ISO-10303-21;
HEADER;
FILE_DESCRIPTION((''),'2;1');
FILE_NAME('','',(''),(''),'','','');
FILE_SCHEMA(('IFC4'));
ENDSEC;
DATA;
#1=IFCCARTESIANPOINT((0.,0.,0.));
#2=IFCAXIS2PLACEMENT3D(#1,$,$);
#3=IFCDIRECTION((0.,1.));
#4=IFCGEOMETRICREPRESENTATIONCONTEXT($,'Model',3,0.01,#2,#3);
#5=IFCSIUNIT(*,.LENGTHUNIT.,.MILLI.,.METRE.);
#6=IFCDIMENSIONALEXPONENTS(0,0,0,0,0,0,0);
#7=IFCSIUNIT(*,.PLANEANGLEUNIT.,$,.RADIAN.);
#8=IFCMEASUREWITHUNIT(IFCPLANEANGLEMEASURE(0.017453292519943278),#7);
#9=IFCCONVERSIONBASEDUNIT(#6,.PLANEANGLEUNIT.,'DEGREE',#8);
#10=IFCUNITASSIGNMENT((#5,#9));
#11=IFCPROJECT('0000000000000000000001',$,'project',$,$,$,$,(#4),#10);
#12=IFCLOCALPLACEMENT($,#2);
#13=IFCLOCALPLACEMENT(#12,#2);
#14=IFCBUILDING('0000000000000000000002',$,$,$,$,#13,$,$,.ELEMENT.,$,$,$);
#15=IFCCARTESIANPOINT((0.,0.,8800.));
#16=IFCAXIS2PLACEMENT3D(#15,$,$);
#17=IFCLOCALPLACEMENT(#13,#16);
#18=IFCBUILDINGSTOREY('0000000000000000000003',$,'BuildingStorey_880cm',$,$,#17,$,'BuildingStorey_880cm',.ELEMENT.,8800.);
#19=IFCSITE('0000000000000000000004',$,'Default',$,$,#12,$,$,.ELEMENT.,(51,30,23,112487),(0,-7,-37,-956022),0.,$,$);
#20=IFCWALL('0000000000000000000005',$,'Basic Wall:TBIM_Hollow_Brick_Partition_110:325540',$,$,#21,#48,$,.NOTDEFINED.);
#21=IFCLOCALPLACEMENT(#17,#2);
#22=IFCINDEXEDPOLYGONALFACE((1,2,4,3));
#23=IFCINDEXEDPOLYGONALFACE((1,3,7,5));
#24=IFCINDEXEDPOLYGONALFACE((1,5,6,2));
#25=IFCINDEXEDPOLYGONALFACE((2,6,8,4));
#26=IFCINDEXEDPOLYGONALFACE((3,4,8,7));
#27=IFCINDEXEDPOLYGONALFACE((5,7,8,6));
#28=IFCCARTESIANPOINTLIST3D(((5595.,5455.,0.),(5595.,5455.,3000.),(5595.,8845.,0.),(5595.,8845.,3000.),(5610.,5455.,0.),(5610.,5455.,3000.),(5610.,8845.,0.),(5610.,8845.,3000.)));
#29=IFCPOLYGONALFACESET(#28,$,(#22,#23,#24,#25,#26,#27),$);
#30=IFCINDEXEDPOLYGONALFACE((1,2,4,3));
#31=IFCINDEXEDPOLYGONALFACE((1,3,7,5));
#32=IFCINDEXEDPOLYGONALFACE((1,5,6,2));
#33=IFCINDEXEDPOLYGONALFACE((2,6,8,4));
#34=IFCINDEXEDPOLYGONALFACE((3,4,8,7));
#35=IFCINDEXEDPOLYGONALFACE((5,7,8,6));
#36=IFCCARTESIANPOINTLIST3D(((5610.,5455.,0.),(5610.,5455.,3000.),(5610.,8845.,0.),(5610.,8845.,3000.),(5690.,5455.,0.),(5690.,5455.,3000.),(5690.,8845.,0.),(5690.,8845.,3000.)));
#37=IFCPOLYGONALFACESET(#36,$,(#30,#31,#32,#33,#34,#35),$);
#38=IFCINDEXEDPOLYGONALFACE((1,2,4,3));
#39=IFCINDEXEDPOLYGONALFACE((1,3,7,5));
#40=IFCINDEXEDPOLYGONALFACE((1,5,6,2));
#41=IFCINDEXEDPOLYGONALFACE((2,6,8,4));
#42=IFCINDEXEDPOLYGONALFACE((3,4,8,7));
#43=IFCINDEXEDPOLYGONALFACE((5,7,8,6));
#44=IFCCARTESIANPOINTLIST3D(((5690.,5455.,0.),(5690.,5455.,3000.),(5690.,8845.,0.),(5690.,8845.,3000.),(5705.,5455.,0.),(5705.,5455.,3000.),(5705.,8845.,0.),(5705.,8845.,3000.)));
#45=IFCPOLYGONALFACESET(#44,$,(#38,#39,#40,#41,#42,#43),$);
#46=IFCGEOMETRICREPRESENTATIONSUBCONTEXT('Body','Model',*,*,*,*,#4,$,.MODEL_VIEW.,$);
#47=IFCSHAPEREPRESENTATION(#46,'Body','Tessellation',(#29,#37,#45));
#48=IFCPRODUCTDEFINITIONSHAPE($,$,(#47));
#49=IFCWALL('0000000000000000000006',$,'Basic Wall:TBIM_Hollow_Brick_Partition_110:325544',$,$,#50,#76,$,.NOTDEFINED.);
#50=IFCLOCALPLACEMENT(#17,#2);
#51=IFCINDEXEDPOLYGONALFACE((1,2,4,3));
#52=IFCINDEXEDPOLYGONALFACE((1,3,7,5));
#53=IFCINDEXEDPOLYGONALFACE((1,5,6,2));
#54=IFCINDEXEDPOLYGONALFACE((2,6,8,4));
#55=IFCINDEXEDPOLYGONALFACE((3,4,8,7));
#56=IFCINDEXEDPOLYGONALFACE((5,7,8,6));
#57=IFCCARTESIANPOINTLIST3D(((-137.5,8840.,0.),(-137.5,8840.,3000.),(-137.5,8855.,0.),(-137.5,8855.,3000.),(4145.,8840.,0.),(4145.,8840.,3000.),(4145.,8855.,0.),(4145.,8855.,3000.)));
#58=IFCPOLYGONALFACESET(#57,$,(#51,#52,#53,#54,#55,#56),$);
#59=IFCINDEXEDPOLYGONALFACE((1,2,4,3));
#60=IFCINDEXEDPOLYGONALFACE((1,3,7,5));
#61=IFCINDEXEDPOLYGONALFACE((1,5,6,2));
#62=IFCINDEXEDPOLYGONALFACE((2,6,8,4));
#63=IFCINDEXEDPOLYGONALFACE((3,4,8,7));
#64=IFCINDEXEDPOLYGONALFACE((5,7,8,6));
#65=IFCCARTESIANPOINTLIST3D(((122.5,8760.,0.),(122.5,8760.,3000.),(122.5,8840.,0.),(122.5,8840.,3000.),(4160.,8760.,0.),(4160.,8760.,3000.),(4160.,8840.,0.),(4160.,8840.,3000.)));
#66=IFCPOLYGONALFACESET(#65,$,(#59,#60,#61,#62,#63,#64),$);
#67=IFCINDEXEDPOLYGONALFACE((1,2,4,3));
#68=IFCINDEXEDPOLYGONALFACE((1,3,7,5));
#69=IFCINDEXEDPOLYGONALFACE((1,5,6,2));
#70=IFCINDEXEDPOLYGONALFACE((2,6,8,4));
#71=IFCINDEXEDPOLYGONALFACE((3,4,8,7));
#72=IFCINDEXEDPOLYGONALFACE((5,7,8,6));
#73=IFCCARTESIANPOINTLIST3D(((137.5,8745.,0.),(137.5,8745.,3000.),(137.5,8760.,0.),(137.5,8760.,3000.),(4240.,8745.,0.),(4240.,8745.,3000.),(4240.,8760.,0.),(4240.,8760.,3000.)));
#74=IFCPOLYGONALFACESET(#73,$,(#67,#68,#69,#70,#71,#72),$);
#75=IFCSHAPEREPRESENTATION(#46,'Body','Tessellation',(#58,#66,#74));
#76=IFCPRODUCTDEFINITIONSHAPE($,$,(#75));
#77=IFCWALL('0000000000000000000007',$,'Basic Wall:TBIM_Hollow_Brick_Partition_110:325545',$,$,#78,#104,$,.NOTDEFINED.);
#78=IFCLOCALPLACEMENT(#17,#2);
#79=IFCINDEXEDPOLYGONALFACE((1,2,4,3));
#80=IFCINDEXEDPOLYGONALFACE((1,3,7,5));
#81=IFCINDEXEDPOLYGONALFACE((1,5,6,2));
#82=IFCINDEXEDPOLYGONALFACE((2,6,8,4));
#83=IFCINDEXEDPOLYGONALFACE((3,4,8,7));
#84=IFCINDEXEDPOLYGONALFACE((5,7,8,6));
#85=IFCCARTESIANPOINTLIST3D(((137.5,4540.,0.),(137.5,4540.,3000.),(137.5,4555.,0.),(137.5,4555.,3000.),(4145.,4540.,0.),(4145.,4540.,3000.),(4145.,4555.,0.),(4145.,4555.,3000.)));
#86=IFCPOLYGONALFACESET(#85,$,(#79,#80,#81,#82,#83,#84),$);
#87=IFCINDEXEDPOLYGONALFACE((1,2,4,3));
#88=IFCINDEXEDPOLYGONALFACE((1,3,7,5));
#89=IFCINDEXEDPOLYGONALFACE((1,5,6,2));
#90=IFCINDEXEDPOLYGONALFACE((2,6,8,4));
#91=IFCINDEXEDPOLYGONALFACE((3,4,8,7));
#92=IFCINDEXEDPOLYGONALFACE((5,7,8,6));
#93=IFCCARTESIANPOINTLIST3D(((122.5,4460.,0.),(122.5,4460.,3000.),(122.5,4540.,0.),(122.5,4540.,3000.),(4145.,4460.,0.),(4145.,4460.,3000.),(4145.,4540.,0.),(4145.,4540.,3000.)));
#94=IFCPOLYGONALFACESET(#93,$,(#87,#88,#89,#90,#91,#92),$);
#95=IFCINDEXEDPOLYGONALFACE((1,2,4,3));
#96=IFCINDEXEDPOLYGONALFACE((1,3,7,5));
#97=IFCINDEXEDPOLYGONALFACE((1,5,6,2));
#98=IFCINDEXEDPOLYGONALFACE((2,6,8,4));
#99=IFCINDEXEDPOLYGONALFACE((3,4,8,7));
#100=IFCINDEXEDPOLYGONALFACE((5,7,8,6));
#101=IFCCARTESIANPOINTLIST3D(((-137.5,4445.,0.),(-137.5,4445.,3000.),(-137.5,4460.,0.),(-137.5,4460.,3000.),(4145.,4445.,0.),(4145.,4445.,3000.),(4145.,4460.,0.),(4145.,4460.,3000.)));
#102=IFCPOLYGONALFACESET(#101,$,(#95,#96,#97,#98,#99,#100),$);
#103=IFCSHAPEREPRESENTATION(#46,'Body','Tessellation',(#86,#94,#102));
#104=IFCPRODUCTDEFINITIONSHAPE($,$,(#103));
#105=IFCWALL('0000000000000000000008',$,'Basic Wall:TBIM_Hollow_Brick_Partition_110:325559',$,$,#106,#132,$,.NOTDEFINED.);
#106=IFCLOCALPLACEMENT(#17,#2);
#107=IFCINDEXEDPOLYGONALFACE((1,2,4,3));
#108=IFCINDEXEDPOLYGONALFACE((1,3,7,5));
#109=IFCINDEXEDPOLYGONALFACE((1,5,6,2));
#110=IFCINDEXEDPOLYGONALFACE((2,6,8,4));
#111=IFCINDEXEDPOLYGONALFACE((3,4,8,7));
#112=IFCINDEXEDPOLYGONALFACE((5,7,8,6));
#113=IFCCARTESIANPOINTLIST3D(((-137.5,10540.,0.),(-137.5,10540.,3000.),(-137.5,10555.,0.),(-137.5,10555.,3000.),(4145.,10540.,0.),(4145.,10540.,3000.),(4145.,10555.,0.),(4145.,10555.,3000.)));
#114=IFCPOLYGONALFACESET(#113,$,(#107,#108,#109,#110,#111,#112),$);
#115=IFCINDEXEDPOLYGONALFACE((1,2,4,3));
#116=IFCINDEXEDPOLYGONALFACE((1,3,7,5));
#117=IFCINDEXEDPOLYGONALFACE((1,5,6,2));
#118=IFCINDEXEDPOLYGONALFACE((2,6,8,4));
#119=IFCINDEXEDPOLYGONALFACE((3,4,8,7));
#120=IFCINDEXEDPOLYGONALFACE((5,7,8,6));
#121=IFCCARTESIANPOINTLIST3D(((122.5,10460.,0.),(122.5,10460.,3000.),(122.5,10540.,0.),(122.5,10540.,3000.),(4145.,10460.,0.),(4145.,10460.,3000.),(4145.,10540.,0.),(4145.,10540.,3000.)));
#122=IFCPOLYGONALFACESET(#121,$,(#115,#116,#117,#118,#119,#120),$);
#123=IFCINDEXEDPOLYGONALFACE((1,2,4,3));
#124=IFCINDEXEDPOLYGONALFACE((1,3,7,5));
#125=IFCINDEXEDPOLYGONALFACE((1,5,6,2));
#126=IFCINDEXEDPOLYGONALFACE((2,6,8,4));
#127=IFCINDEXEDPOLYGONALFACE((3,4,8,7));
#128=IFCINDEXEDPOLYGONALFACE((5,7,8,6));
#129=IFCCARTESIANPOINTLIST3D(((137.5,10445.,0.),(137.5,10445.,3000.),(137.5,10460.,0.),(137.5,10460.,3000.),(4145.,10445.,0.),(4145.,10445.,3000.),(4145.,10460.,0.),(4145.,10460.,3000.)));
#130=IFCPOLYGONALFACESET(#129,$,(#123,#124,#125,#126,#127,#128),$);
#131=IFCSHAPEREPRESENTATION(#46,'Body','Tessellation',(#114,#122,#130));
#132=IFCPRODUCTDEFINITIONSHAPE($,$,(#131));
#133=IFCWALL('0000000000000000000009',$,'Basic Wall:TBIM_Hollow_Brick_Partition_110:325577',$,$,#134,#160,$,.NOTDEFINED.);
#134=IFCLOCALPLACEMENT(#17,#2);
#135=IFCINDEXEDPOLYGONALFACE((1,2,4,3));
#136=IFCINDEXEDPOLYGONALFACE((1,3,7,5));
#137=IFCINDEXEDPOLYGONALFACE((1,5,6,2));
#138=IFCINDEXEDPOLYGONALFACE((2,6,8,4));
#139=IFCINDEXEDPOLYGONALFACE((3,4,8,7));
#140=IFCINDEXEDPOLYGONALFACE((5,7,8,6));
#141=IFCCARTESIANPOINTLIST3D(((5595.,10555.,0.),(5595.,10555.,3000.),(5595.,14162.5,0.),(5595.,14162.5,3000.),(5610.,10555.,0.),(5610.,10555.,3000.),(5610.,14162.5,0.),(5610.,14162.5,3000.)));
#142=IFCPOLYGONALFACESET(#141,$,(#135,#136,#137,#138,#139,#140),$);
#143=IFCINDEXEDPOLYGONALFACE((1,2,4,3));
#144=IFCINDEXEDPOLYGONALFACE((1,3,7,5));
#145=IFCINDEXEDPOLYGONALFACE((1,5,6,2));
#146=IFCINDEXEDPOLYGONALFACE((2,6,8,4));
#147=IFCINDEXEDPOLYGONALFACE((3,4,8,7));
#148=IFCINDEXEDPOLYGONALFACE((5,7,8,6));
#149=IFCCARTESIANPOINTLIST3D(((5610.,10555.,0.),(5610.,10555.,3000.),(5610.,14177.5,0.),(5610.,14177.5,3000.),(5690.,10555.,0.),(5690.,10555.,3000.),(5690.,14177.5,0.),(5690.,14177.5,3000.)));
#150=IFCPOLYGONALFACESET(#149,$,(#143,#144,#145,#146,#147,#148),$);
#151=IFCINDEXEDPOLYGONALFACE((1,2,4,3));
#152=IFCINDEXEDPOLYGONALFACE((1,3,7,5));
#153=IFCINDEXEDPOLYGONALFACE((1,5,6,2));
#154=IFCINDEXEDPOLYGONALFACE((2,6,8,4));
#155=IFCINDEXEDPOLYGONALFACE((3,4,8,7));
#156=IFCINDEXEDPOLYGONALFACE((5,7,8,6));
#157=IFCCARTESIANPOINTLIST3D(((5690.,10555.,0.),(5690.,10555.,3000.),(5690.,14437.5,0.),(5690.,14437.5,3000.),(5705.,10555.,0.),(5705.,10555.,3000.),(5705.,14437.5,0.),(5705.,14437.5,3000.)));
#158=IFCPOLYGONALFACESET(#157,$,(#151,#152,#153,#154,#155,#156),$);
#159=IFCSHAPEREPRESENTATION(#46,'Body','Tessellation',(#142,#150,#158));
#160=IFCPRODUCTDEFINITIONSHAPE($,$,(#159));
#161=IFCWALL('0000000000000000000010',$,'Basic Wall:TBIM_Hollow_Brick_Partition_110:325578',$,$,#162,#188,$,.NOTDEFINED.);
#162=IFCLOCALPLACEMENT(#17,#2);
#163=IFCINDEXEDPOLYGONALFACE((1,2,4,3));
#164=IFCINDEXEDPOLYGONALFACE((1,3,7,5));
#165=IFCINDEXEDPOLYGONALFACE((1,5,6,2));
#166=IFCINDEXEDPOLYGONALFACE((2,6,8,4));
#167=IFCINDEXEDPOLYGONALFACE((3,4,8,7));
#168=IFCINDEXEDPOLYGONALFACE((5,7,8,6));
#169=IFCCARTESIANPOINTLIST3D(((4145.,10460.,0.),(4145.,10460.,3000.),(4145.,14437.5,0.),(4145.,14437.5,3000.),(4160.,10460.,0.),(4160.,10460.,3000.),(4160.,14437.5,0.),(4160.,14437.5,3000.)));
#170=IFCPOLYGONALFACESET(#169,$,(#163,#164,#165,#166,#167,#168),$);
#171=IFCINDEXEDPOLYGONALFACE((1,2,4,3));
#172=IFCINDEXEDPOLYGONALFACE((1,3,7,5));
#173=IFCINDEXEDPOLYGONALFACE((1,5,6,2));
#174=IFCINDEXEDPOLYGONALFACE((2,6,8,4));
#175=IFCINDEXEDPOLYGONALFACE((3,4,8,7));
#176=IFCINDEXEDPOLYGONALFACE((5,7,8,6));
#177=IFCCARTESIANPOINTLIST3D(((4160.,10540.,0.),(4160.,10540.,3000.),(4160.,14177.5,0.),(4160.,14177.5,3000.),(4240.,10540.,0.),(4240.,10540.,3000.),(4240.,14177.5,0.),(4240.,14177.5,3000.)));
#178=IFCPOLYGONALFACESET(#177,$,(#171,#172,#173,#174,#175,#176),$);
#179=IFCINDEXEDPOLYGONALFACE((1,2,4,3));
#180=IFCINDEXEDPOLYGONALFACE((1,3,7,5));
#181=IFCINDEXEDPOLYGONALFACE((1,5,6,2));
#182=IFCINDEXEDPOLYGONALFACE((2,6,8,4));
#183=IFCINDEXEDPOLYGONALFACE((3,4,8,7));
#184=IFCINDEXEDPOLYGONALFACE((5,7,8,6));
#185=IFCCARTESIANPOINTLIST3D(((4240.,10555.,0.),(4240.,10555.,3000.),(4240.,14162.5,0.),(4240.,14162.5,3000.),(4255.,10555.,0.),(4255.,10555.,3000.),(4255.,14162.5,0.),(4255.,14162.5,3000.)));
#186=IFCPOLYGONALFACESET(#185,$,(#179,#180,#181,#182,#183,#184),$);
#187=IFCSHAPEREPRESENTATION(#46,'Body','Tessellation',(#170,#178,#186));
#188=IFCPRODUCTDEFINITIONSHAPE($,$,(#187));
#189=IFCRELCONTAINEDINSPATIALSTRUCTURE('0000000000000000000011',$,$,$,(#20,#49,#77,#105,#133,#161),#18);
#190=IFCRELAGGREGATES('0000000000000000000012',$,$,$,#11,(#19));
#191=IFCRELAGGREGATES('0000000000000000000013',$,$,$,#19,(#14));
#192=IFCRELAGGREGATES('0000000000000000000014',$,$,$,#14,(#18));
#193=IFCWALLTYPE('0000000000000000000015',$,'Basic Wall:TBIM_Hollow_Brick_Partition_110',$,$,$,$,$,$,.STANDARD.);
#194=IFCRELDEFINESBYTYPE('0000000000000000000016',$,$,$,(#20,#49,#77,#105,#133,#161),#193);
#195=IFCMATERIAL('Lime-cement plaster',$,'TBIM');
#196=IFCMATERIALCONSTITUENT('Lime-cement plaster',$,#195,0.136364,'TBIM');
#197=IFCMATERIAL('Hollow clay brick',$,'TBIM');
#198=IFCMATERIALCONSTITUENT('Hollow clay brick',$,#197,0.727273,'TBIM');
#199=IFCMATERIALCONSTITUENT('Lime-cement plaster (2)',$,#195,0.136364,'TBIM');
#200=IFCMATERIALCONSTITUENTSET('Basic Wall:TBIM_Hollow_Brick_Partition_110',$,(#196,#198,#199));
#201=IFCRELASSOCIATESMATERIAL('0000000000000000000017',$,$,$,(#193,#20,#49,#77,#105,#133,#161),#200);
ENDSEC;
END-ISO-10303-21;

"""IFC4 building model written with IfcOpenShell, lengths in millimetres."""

from ifc_helpers import new_model, entity, si_unit, converted_unit, direction, frame, origin, place, context, subcontext, project, spatial, indexed_curve, outline, extrude, material, constituent, constituent_set, type_object, element, save


model = new_model("IFC4")

# Units and contexts
model_context = context("Model", 3, precision=0.01, world=origin(), true_north=direction((0.0, 1.0)))
body_context = subcontext(model_context, "Body", "Model", "MODEL_VIEW")
ifc_project = project(units=[si_unit("LENGTHUNIT", "METRE", prefix="MILLI"), converted_unit("PLANEANGLEUNIT", "DEGREE", entity("IfcPlaneAngleMeasure", 0.017453292519943278), si_unit("PLANEANGLEUNIT", "RADIAN"), dimensions=[0, 0, 0, 0, 0, 0, 0])], contexts=[model_context])

# Site, building, storey
site_placement = place(None, origin())
site = spatial("IfcSite", under=ifc_project, at=site_placement, Name="Default", CompositionType="ELEMENT", RefLatitude=(51, 30, 23, 112487), RefLongitude=(0, -7, -37, -956022), RefElevation=0.0)
building_placement = place(site_placement, origin())
building = spatial("IfcBuilding", under=site, at=building_placement, CompositionType="ELEMENT")
storey_placement = place(building_placement, frame((0.0, 0.0, 8800.0)))
storey = spatial("IfcBuildingStorey", under=building, at=storey_placement, Name="BuildingStorey_880cm", LongName="BuildingStorey_880cm", CompositionType="ELEMENT", Elevation=8800.0)

# Shared definitions
ifc_material_1 = material(Name="Lime-cement plaster", Category="TBIM")

# Shared definitions
ifc_material_2 = material(Name="Hollow clay brick", Category="TBIM")

# Shared definitions
ifc_constituent_1 = constituent(ifc_material_1, Name="Lime-cement plaster", Category="TBIM", fraction=0.136364)
ifc_constituent_2 = constituent(ifc_material_2, Name="Hollow clay brick", Category="TBIM", fraction=0.727273)
ifc_constituent_3 = constituent(ifc_material_1, Name="Lime-cement plaster (2)", Category="TBIM", fraction=0.136364)
ifc_constituent_set_1 = constituent_set(constituents=[ifc_constituent_1, ifc_constituent_2, ifc_constituent_3], Name="Basic Wall:TBIM_Hollow_Brick_Partition_110")
wall_type_1 = type_object("IfcWallType", Name="Basic Wall:TBIM_Hollow_Brick_Partition_110", PredefinedType="STANDARD", material=ifc_constituent_set_1)

# Wall
wall_1_placement = place(storey_placement, frame((5650.0, 5455.0, 0.0), z_axis=(0.0, 0.0, 1.0), x_axis=(0.0, 1.0, 0.0)))
element("IfcWall", 1, at=wall_1_placement, inside=storey, type_object=wall_type_1, material=ifc_constituent_set_1, Name="Basic Wall:TBIM_Hollow_Brick_Partition_110:325540", PredefinedType="NOTDEFINED", context=body_context, shape_type="SweptSolid", body=[
    extrude(outline(indexed_curve([(-7.5, -1695.0), (7.5, -1695.0), (7.5, 1695.0), (-7.5, 1695.0), (-7.5, -1695.0)], self_intersect=False)), frame((1695.0, 47.5, 0.0), z_axis=(0.0, 0.0, 1.0), x_axis=(0.0, -1.0, 0.0)), (0.0, 0.0, 1.0), 3000.0),
    extrude(outline(indexed_curve([(-1695.0, -40.0), (1695.0, -40.0), (1695.0, 40.0), (-1695.0, 40.0), (-1695.0, -40.0)], self_intersect=False)), frame((1695.0, 0.0, 0.0)), (0.0, 0.0, 1.0), 3000.0),
    extrude(outline(indexed_curve([(-7.5, -1695.0), (7.5, -1695.0), (7.5, 1695.0), (-7.5, 1695.0), (-7.5, -1695.0)], self_intersect=False)), frame((1695.0, -47.5, 0.0), z_axis=(0.0, 0.0, 1.0), x_axis=(0.0, 1.0, 0.0)), (0.0, 0.0, 1.0), 3000.0),
])

# Walls
wall_2_placement = place(storey_placement, frame((137.5, 8800.0, 0.0)))
element("IfcWall", 2, at=wall_2_placement, inside=storey, type_object=wall_type_1, material=ifc_constituent_set_1, Name="Basic Wall:TBIM_Hollow_Brick_Partition_110:325544", PredefinedType="NOTDEFINED", context=body_context, shape_type="SweptSolid", body=[
    extrude(outline(indexed_curve([(-7.5, -2141.2), (7.5, -2141.2), (7.5, 2141.2), (-7.5, 2141.2), (-7.5, -2141.2)], self_intersect=False)), frame((1866.2, 47.5, 0.0), z_axis=(0.0, 0.0, 1.0), x_axis=(0.0, -1.0, 0.0)), (0.0, 0.0, 1.0), 3000.0),
    extrude(outline(indexed_curve([(-2018.7, -40.0), (2018.7, -40.0), (2018.7, 40.0), (-2018.7, 40.0), (-2018.7, -40.0)], self_intersect=False)), frame((2003.7, 0.0, 0.0)), (0.0, 0.0, 1.0), 3000.0),
    extrude(outline(indexed_curve([(-7.5, -2051.2), (7.5, -2051.2), (7.5, 2051.2), (-7.5, 2051.2), (-7.5, -2051.2)], self_intersect=False)), frame((2051.2, -47.5, 0.0), z_axis=(0.0, 0.0, 1.0), x_axis=(0.0, 1.0, 0.0)), (0.0, 0.0, 1.0), 3000.0),
])
wall_3_placement = place(storey_placement, frame((137.5, 4500.0, 0.0)))
element("IfcWall", 3, at=wall_3_placement, inside=storey, type_object=wall_type_1, material=ifc_constituent_set_1, Name="Basic Wall:TBIM_Hollow_Brick_Partition_110:325545", PredefinedType="NOTDEFINED", context=body_context, shape_type="SweptSolid", body=[
    extrude(outline(indexed_curve([(-7.5, -2003.7), (7.5, -2003.7), (7.5, 2003.7), (-7.5, 2003.7), (-7.5, -2003.7)], self_intersect=False)), frame((2003.7, 47.5, 0.0), z_axis=(0.0, 0.0, 1.0), x_axis=(0.0, -1.0, 0.0)), (0.0, 0.0, 1.0), 3000.0),
    extrude(outline(indexed_curve([(-2011.2, -40.0), (2011.2, -40.0), (2011.2, 40.0), (-2011.2, 40.0), (-2011.2, -40.0)], self_intersect=False)), frame((1996.2, 0.0, 0.0)), (0.0, 0.0, 1.0), 3000.0),
    extrude(outline(indexed_curve([(-7.5, -2141.2), (7.5, -2141.2), (7.5, 2141.2), (-7.5, 2141.2), (-7.5, -2141.2)], self_intersect=False)), frame((1866.2, -47.5, 0.0), z_axis=(0.0, 0.0, 1.0), x_axis=(0.0, 1.0, 0.0)), (0.0, 0.0, 1.0), 3000.0),
])
wall_4_placement = place(storey_placement, frame((137.5, 10500.0, 0.0)))
element("IfcWall", 4, at=wall_4_placement, inside=storey, type_object=wall_type_1, material=ifc_constituent_set_1, Name="Basic Wall:TBIM_Hollow_Brick_Partition_110:325559", PredefinedType="NOTDEFINED", context=body_context, shape_type="SweptSolid", body=[
    extrude(outline(indexed_curve([(-7.5, -2141.2), (7.5, -2141.2), (7.5, 2141.2), (-7.5, 2141.2), (-7.5, -2141.2)], self_intersect=False)), frame((1866.2, 47.5, 0.0), z_axis=(0.0, 0.0, 1.0), x_axis=(0.0, -1.0, 0.0)), (0.0, 0.0, 1.0), 3000.0),
    extrude(outline(indexed_curve([(-2011.2, -40.0), (2011.2, -40.0), (2011.2, 40.0), (-2011.2, 40.0), (-2011.2, -40.0)], self_intersect=False)), frame((1996.2, 0.0, 0.0)), (0.0, 0.0, 1.0), 3000.0),
    extrude(outline(indexed_curve([(-7.5, -2003.7), (7.5, -2003.7), (7.5, 2003.7), (-7.5, 2003.7), (-7.5, -2003.7)], self_intersect=False)), frame((2003.7, -47.5, 0.0), z_axis=(0.0, 0.0, 1.0), x_axis=(0.0, 1.0, 0.0)), (0.0, 0.0, 1.0), 3000.0),
])
wall_5_placement = place(storey_placement, frame((5650.0, 10555.0, 0.0), z_axis=(0.0, 0.0, 1.0), x_axis=(0.0, 1.0, 0.0)))
element("IfcWall", 5, at=wall_5_placement, inside=storey, type_object=wall_type_1, material=ifc_constituent_set_1, Name="Basic Wall:TBIM_Hollow_Brick_Partition_110:325577", PredefinedType="NOTDEFINED", context=body_context, shape_type="SweptSolid", body=[
    extrude(outline(indexed_curve([(-7.5, -1803.7), (7.5, -1803.7), (7.5, 1803.8), (-7.5, 1803.8), (-7.5, -1803.7)], self_intersect=False)), frame((1803.7, 47.5, 0.0), z_axis=(0.0, 0.0, 1.0), x_axis=(0.0, -1.0, 0.0)), (0.0, 0.0, 1.0), 3000.0),
    extrude(outline(indexed_curve([(-1811.3, -40.0), (1811.2, -40.0), (1811.2, 40.0), (-1811.3, 40.0), (-1811.3, -40.0)], self_intersect=False)), frame((1811.3, 0.0, 0.0)), (0.0, 0.0, 1.0), 3000.0),
    extrude(outline(indexed_curve([(-7.5, -1941.3), (7.5, -1941.3), (7.5, 1941.3), (-7.5, 1941.3), (-7.5, -1941.3)], self_intersect=False)), frame((1941.3, -47.5, 0.0), z_axis=(0.0, 0.0, 1.0), x_axis=(0.0, 1.0, 0.0)), (0.0, 0.0, 1.0), 3000.0),
])
wall_6_placement = place(storey_placement, frame((4200.0, 10555.0, 0.0), z_axis=(0.0, 0.0, 1.0), x_axis=(0.0, 1.0, 0.0)))
element("IfcWall", 6, at=wall_6_placement, inside=storey, type_object=wall_type_1, material=ifc_constituent_set_1, Name="Basic Wall:TBIM_Hollow_Brick_Partition_110:325578", PredefinedType="NOTDEFINED", context=body_context, shape_type="SweptSolid", body=[
    extrude(outline(indexed_curve([(-7.5, -1988.8), (7.5, -1988.8), (7.5, 1988.8), (-7.5, 1988.8), (-7.5, -1988.8)], self_intersect=False)), frame((1893.8, 47.5, 0.0), z_axis=(0.0, 0.0, 1.0), x_axis=(0.0, -1.0, 0.0)), (0.0, 0.0, 1.0), 3000.0),
    extrude(outline(indexed_curve([(-1818.8, -40.0), (1818.8, -40.0), (1818.8, 40.0), (-1818.8, 40.0), (-1818.8, -40.0)], self_intersect=False)), frame((1803.7, 0.0, 0.0)), (0.0, 0.0, 1.0), 3000.0),
    extrude(outline(indexed_curve([(-7.5, -1803.8), (7.5, -1803.8), (7.5, 1803.7), (-7.5, 1803.7), (-7.5, -1803.8)], self_intersect=False)), frame((1803.7, -47.5, 0.0), z_axis=(0.0, 0.0, 1.0), x_axis=(0.0, 1.0, 0.0)), (0.0, 0.0, 1.0), 3000.0),
])

save(model, "model.ifc")
